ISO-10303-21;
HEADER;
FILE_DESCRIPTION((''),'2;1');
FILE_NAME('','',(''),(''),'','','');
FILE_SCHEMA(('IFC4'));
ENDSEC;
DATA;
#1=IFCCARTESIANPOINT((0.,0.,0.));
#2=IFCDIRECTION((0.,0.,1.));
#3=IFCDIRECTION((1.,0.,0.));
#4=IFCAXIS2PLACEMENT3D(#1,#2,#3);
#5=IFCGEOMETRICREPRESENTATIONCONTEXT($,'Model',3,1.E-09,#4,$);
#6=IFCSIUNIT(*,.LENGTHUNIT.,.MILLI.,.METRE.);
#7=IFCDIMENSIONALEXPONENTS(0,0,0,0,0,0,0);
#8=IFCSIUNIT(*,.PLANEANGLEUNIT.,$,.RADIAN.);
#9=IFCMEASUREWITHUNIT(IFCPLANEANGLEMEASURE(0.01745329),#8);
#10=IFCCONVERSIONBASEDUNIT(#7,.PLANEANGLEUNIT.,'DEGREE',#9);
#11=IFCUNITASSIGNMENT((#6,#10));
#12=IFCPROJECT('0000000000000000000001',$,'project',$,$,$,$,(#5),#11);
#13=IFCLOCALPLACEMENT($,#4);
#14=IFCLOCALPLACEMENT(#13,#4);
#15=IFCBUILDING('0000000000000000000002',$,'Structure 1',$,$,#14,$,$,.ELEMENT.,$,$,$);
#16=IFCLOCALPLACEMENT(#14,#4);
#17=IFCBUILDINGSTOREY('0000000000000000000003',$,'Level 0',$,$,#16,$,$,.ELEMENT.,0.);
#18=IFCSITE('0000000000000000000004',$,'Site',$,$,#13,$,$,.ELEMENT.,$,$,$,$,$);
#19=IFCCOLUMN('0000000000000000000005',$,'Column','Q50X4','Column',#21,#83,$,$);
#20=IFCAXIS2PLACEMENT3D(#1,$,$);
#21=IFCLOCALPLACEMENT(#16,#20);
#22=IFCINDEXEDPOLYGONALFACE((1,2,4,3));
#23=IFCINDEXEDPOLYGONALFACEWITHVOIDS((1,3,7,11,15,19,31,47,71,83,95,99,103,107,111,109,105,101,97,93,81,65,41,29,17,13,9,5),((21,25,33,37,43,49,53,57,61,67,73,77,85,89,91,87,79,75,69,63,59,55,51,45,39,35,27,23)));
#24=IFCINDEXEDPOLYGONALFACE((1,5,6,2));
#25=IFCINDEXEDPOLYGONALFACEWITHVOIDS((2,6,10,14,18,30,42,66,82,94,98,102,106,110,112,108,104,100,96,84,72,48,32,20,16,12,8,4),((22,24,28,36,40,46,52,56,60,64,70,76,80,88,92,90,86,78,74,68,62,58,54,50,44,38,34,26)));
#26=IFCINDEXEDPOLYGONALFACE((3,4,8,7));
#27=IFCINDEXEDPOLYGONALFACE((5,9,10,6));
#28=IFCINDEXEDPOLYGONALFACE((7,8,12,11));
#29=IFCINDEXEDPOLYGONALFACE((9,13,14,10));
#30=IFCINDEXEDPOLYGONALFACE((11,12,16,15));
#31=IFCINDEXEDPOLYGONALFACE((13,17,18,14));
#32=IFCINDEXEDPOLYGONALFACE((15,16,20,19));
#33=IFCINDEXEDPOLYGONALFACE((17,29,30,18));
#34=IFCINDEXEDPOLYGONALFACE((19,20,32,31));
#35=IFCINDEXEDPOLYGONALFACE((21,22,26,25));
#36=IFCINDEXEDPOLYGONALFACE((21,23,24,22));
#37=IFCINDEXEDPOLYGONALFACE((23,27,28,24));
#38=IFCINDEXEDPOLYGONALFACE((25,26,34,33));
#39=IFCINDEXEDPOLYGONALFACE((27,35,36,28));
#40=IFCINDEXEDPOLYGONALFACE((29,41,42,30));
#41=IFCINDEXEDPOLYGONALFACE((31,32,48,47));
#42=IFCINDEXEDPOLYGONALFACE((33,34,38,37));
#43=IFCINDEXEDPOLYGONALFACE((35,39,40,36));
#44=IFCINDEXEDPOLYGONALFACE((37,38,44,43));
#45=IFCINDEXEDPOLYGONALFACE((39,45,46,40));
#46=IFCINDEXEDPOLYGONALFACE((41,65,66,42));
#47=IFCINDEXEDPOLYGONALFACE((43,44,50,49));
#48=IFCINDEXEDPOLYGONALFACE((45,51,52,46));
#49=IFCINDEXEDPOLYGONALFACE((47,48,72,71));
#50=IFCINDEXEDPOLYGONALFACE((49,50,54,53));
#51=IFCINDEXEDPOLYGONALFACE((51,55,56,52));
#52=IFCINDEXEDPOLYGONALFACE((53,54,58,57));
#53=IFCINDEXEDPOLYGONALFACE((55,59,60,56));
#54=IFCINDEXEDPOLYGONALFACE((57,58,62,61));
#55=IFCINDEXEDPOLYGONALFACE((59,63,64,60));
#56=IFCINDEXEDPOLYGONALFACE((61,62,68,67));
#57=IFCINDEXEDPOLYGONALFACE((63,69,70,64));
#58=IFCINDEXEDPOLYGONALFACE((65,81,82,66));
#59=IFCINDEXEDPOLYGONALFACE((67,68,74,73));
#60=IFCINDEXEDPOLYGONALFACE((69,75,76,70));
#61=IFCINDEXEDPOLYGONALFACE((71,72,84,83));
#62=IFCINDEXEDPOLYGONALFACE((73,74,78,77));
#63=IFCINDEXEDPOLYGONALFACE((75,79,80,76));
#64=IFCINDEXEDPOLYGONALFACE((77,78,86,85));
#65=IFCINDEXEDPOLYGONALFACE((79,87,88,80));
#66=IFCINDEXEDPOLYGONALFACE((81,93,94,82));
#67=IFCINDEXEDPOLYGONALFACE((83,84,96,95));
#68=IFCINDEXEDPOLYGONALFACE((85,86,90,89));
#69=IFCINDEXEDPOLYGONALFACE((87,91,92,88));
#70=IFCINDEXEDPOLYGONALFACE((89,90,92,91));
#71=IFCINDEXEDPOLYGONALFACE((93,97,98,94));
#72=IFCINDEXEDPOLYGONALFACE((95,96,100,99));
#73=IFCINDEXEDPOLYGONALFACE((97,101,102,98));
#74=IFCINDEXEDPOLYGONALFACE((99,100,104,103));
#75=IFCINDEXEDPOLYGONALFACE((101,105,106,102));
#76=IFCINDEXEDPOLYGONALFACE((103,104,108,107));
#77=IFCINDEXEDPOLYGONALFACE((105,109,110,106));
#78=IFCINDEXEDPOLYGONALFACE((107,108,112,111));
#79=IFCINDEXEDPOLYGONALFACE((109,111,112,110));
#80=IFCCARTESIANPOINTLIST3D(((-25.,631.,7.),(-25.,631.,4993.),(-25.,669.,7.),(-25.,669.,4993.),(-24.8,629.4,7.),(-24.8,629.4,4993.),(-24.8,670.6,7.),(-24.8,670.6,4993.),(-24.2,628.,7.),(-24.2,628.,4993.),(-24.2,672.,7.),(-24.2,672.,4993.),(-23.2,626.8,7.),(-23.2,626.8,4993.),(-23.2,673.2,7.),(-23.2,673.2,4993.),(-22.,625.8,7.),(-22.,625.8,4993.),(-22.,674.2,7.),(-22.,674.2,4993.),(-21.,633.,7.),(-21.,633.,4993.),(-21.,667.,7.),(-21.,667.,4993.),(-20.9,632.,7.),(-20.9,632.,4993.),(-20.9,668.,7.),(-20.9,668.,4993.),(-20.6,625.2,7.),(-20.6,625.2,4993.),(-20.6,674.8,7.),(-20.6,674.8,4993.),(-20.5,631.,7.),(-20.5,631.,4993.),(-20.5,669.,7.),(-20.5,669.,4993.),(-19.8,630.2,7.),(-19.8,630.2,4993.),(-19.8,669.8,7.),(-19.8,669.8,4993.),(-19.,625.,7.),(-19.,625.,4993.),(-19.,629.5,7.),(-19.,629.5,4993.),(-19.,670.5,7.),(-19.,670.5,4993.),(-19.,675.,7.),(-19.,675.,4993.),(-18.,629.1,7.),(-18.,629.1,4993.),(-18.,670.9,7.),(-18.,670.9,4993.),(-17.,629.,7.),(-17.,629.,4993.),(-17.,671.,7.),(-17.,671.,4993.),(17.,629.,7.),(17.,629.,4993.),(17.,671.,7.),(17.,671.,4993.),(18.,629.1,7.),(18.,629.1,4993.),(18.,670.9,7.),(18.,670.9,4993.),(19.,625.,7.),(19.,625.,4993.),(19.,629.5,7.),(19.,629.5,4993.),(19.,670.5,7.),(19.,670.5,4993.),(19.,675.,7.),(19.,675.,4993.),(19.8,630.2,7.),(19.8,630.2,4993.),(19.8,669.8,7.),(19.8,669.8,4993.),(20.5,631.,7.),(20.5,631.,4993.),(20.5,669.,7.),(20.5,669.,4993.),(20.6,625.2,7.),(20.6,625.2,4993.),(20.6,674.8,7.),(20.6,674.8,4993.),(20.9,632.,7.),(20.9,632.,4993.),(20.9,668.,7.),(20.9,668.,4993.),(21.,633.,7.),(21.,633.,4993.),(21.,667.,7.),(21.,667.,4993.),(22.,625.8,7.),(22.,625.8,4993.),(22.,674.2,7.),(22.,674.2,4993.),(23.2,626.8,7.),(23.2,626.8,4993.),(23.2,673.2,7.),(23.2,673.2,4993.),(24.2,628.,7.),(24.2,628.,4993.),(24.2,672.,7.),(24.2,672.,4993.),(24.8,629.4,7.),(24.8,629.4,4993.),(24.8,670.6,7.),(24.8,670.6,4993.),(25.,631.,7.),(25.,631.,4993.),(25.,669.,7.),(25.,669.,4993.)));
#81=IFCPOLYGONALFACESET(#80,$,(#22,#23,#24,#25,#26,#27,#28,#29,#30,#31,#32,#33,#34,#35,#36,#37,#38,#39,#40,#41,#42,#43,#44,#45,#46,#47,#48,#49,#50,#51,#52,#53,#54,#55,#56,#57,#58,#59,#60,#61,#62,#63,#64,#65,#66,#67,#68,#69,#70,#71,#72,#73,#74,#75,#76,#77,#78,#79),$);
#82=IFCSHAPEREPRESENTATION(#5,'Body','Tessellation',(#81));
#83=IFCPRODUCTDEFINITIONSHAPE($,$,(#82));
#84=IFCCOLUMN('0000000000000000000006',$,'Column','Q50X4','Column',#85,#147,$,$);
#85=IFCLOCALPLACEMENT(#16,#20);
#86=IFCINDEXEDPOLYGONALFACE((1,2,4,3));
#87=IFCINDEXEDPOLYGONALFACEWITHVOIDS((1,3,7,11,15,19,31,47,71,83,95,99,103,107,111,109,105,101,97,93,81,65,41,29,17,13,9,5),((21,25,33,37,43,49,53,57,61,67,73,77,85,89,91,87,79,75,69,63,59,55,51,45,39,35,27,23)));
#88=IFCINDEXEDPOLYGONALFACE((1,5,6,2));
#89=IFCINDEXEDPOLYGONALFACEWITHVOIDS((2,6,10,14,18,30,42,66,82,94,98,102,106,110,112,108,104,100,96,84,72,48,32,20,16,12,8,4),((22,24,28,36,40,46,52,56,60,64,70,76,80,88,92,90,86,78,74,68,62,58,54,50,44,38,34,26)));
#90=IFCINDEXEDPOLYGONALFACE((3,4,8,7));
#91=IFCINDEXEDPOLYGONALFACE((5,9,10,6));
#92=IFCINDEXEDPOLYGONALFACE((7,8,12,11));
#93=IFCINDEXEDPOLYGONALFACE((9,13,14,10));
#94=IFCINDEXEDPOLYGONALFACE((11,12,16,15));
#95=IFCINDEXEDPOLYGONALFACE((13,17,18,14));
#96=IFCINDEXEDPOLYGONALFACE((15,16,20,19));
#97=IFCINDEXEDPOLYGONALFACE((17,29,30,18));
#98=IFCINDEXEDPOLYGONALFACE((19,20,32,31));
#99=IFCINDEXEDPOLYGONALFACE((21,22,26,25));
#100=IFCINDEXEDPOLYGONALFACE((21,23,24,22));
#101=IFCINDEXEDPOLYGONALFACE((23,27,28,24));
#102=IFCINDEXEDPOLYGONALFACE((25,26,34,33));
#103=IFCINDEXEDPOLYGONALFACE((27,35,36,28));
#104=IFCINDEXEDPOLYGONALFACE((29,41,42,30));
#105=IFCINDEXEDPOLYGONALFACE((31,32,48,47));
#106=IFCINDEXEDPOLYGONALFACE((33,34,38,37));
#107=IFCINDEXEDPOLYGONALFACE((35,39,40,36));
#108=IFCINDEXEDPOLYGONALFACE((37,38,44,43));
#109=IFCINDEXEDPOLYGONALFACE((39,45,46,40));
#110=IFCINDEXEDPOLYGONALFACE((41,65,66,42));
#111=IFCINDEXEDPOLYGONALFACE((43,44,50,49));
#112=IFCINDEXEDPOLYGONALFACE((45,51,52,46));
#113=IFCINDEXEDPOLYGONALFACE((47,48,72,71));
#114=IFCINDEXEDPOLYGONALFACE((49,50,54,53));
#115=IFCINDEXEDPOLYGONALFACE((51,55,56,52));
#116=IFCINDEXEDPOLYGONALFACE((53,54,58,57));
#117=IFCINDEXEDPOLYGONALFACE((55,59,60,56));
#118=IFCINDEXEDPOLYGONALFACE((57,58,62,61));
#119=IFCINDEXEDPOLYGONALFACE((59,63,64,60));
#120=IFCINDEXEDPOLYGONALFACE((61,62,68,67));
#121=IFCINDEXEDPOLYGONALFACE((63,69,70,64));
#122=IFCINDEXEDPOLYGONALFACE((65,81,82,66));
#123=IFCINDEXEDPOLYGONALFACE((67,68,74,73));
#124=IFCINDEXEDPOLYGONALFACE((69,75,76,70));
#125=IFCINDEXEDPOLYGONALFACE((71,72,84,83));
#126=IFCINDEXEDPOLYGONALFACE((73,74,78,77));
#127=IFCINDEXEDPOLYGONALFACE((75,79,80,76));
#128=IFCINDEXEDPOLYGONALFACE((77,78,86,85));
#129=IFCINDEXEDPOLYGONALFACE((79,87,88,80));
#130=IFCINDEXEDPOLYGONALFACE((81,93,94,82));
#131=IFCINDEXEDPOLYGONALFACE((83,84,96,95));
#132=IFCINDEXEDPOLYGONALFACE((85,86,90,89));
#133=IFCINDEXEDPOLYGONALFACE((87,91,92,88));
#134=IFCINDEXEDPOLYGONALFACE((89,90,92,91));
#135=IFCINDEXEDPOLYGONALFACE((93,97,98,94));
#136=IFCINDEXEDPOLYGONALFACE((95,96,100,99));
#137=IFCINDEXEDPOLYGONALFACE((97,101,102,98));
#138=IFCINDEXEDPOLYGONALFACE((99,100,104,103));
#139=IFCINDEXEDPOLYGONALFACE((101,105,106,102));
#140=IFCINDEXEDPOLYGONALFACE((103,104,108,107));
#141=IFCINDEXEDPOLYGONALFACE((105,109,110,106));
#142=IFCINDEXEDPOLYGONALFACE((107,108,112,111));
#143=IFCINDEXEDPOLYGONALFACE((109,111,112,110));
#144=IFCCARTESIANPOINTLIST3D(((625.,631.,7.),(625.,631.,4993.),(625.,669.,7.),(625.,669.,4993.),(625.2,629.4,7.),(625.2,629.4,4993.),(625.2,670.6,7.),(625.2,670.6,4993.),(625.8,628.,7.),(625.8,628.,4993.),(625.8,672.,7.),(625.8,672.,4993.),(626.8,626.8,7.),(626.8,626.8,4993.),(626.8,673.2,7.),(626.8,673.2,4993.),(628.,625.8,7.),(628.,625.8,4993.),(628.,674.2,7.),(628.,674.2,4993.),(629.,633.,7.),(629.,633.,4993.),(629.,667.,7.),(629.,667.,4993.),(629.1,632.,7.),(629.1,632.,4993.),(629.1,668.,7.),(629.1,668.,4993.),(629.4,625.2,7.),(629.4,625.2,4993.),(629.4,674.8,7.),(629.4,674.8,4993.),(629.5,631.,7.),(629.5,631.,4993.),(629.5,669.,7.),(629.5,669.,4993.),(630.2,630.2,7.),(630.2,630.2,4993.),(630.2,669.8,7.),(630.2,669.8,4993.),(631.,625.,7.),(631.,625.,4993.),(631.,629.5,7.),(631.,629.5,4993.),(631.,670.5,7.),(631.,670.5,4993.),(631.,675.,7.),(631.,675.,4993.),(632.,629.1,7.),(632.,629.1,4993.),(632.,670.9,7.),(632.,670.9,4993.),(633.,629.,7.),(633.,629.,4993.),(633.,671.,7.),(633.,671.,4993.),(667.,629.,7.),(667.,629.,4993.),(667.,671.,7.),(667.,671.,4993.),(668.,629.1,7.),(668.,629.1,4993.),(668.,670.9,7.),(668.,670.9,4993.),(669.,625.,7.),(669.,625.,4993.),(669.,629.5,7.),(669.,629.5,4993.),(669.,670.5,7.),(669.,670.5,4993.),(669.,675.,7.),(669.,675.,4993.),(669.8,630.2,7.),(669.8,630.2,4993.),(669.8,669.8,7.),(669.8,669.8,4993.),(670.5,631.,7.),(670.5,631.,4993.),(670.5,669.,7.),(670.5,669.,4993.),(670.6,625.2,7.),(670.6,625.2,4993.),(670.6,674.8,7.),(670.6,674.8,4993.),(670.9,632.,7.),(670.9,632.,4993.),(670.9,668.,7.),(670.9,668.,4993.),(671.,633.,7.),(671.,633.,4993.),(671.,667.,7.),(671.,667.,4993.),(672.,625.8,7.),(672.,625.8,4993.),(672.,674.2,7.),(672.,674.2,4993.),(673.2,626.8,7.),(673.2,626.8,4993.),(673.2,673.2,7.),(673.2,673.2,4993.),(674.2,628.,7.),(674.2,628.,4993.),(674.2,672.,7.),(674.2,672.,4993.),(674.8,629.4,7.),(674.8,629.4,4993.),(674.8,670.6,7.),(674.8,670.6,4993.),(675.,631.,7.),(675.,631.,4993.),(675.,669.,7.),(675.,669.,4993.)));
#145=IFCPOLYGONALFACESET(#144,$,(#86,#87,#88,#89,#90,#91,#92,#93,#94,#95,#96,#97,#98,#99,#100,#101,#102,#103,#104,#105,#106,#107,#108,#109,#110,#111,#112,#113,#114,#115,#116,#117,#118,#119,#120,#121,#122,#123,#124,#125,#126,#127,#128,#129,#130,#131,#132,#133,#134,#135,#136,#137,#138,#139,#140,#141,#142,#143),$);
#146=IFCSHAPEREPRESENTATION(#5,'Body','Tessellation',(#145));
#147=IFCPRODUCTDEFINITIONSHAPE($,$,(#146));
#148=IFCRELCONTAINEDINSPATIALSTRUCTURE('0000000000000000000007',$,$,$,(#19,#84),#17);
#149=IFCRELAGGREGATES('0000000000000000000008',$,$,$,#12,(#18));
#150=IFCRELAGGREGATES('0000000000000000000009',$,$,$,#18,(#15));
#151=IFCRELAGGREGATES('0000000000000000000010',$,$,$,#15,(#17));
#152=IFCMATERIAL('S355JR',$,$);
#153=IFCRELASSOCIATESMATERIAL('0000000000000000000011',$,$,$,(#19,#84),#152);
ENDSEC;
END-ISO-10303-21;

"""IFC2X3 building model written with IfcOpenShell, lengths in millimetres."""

from ifc_helpers import new_model, entity, si_unit, converted_unit, frame, origin, origin_with_axes, origin_2d, place, context, project, spatial, hollow_rectangle, extrude, clip, halfspace, material, element, save


model = new_model("IFC2X3")

# Units and contexts
model_context = context("Model", 3, precision=1e-09, world=origin_with_axes())
ifc_project = project(units=[si_unit("LENGTHUNIT", "METRE", prefix="MILLI"), converted_unit("PLANEANGLEUNIT", "DEGREE", entity("IfcPlaneAngleMeasure", 0.01745329), si_unit("PLANEANGLEUNIT", "RADIAN"), dimensions=[0, 0, 0, 0, 0, 0, 0])], contexts=[model_context])

# Site, building, storey
site_placement = place(None, origin_with_axes())
site = spatial("IfcSite", under=ifc_project, at=site_placement, Name="Site", CompositionType="ELEMENT")
building_placement = place(site_placement, origin_with_axes())
building = spatial("IfcBuilding", under=site, at=building_placement, Name="Structure 1", CompositionType="ELEMENT")
storey_placement = place(building_placement, origin_with_axes())
storey = spatial("IfcBuildingStorey", under=building, at=storey_placement, Name="Level 0", CompositionType="ELEMENT", Elevation=0.0)

# Columns
ifc_material_1 = material(Name="S355JR")
column_1_placement = place(None, frame((0.0, 650.0, -35.4), z_axis=(0.0, 0.0, -1.0), x_axis=(-1.0, 0.0, 0.0)))
element("IfcColumn", 1, at=column_1_placement, inside=storey, material=ifc_material_1, Name="Column", Description="Q50X4", ObjectType="Column", context=model_context, shape_type="Clipping", body=[
    clip(clip(extrude(hollow_rectangle(XDim=50.0, YDim=50.0, WallThickness=4.0, InnerFilletRadius=4.0, OuterFilletRadius=6.0, at=origin_2d()), origin(), (0.0, 0.0, -1.0), 5070.7), halfspace(frame((0.0, -650.0, -42.4), z_axis=(0.0, 0.0, -1.0), x_axis=(-1.0, 0.0, 0.0)), True)), halfspace(frame((0.0, -650.0, -5028.4), z_axis=(0.0, 0.0, 1.0), x_axis=(1.0, 0.0, 0.0)), True)),
])
column_2_placement = place(None, frame((650.0, 650.0, -35.4), z_axis=(0.0, 0.0, -1.0), x_axis=(-1.0, 0.0, 0.0)))
element("IfcColumn", 2, at=column_2_placement, inside=storey, material=ifc_material_1, Name="Column", Description="Q50X4", ObjectType="Column", context=model_context, shape_type="Clipping", body=[
    clip(clip(extrude(hollow_rectangle(XDim=50.0, YDim=50.0, WallThickness=4.0, InnerFilletRadius=4.0, OuterFilletRadius=6.0, at=origin_2d()), origin(), (0.0, 0.0, -1.0), 5070.7), halfspace(frame((650.0, -650.0, -42.4), z_axis=(0.0, 0.0, -1.0), x_axis=(-1.0, 0.0, 0.0)), True)), halfspace(frame((650.0, -650.0, -5028.4), z_axis=(0.0, 0.0, 1.0), x_axis=(1.0, 0.0, 0.0)), True)),
])

save(model, "model.ifc")
